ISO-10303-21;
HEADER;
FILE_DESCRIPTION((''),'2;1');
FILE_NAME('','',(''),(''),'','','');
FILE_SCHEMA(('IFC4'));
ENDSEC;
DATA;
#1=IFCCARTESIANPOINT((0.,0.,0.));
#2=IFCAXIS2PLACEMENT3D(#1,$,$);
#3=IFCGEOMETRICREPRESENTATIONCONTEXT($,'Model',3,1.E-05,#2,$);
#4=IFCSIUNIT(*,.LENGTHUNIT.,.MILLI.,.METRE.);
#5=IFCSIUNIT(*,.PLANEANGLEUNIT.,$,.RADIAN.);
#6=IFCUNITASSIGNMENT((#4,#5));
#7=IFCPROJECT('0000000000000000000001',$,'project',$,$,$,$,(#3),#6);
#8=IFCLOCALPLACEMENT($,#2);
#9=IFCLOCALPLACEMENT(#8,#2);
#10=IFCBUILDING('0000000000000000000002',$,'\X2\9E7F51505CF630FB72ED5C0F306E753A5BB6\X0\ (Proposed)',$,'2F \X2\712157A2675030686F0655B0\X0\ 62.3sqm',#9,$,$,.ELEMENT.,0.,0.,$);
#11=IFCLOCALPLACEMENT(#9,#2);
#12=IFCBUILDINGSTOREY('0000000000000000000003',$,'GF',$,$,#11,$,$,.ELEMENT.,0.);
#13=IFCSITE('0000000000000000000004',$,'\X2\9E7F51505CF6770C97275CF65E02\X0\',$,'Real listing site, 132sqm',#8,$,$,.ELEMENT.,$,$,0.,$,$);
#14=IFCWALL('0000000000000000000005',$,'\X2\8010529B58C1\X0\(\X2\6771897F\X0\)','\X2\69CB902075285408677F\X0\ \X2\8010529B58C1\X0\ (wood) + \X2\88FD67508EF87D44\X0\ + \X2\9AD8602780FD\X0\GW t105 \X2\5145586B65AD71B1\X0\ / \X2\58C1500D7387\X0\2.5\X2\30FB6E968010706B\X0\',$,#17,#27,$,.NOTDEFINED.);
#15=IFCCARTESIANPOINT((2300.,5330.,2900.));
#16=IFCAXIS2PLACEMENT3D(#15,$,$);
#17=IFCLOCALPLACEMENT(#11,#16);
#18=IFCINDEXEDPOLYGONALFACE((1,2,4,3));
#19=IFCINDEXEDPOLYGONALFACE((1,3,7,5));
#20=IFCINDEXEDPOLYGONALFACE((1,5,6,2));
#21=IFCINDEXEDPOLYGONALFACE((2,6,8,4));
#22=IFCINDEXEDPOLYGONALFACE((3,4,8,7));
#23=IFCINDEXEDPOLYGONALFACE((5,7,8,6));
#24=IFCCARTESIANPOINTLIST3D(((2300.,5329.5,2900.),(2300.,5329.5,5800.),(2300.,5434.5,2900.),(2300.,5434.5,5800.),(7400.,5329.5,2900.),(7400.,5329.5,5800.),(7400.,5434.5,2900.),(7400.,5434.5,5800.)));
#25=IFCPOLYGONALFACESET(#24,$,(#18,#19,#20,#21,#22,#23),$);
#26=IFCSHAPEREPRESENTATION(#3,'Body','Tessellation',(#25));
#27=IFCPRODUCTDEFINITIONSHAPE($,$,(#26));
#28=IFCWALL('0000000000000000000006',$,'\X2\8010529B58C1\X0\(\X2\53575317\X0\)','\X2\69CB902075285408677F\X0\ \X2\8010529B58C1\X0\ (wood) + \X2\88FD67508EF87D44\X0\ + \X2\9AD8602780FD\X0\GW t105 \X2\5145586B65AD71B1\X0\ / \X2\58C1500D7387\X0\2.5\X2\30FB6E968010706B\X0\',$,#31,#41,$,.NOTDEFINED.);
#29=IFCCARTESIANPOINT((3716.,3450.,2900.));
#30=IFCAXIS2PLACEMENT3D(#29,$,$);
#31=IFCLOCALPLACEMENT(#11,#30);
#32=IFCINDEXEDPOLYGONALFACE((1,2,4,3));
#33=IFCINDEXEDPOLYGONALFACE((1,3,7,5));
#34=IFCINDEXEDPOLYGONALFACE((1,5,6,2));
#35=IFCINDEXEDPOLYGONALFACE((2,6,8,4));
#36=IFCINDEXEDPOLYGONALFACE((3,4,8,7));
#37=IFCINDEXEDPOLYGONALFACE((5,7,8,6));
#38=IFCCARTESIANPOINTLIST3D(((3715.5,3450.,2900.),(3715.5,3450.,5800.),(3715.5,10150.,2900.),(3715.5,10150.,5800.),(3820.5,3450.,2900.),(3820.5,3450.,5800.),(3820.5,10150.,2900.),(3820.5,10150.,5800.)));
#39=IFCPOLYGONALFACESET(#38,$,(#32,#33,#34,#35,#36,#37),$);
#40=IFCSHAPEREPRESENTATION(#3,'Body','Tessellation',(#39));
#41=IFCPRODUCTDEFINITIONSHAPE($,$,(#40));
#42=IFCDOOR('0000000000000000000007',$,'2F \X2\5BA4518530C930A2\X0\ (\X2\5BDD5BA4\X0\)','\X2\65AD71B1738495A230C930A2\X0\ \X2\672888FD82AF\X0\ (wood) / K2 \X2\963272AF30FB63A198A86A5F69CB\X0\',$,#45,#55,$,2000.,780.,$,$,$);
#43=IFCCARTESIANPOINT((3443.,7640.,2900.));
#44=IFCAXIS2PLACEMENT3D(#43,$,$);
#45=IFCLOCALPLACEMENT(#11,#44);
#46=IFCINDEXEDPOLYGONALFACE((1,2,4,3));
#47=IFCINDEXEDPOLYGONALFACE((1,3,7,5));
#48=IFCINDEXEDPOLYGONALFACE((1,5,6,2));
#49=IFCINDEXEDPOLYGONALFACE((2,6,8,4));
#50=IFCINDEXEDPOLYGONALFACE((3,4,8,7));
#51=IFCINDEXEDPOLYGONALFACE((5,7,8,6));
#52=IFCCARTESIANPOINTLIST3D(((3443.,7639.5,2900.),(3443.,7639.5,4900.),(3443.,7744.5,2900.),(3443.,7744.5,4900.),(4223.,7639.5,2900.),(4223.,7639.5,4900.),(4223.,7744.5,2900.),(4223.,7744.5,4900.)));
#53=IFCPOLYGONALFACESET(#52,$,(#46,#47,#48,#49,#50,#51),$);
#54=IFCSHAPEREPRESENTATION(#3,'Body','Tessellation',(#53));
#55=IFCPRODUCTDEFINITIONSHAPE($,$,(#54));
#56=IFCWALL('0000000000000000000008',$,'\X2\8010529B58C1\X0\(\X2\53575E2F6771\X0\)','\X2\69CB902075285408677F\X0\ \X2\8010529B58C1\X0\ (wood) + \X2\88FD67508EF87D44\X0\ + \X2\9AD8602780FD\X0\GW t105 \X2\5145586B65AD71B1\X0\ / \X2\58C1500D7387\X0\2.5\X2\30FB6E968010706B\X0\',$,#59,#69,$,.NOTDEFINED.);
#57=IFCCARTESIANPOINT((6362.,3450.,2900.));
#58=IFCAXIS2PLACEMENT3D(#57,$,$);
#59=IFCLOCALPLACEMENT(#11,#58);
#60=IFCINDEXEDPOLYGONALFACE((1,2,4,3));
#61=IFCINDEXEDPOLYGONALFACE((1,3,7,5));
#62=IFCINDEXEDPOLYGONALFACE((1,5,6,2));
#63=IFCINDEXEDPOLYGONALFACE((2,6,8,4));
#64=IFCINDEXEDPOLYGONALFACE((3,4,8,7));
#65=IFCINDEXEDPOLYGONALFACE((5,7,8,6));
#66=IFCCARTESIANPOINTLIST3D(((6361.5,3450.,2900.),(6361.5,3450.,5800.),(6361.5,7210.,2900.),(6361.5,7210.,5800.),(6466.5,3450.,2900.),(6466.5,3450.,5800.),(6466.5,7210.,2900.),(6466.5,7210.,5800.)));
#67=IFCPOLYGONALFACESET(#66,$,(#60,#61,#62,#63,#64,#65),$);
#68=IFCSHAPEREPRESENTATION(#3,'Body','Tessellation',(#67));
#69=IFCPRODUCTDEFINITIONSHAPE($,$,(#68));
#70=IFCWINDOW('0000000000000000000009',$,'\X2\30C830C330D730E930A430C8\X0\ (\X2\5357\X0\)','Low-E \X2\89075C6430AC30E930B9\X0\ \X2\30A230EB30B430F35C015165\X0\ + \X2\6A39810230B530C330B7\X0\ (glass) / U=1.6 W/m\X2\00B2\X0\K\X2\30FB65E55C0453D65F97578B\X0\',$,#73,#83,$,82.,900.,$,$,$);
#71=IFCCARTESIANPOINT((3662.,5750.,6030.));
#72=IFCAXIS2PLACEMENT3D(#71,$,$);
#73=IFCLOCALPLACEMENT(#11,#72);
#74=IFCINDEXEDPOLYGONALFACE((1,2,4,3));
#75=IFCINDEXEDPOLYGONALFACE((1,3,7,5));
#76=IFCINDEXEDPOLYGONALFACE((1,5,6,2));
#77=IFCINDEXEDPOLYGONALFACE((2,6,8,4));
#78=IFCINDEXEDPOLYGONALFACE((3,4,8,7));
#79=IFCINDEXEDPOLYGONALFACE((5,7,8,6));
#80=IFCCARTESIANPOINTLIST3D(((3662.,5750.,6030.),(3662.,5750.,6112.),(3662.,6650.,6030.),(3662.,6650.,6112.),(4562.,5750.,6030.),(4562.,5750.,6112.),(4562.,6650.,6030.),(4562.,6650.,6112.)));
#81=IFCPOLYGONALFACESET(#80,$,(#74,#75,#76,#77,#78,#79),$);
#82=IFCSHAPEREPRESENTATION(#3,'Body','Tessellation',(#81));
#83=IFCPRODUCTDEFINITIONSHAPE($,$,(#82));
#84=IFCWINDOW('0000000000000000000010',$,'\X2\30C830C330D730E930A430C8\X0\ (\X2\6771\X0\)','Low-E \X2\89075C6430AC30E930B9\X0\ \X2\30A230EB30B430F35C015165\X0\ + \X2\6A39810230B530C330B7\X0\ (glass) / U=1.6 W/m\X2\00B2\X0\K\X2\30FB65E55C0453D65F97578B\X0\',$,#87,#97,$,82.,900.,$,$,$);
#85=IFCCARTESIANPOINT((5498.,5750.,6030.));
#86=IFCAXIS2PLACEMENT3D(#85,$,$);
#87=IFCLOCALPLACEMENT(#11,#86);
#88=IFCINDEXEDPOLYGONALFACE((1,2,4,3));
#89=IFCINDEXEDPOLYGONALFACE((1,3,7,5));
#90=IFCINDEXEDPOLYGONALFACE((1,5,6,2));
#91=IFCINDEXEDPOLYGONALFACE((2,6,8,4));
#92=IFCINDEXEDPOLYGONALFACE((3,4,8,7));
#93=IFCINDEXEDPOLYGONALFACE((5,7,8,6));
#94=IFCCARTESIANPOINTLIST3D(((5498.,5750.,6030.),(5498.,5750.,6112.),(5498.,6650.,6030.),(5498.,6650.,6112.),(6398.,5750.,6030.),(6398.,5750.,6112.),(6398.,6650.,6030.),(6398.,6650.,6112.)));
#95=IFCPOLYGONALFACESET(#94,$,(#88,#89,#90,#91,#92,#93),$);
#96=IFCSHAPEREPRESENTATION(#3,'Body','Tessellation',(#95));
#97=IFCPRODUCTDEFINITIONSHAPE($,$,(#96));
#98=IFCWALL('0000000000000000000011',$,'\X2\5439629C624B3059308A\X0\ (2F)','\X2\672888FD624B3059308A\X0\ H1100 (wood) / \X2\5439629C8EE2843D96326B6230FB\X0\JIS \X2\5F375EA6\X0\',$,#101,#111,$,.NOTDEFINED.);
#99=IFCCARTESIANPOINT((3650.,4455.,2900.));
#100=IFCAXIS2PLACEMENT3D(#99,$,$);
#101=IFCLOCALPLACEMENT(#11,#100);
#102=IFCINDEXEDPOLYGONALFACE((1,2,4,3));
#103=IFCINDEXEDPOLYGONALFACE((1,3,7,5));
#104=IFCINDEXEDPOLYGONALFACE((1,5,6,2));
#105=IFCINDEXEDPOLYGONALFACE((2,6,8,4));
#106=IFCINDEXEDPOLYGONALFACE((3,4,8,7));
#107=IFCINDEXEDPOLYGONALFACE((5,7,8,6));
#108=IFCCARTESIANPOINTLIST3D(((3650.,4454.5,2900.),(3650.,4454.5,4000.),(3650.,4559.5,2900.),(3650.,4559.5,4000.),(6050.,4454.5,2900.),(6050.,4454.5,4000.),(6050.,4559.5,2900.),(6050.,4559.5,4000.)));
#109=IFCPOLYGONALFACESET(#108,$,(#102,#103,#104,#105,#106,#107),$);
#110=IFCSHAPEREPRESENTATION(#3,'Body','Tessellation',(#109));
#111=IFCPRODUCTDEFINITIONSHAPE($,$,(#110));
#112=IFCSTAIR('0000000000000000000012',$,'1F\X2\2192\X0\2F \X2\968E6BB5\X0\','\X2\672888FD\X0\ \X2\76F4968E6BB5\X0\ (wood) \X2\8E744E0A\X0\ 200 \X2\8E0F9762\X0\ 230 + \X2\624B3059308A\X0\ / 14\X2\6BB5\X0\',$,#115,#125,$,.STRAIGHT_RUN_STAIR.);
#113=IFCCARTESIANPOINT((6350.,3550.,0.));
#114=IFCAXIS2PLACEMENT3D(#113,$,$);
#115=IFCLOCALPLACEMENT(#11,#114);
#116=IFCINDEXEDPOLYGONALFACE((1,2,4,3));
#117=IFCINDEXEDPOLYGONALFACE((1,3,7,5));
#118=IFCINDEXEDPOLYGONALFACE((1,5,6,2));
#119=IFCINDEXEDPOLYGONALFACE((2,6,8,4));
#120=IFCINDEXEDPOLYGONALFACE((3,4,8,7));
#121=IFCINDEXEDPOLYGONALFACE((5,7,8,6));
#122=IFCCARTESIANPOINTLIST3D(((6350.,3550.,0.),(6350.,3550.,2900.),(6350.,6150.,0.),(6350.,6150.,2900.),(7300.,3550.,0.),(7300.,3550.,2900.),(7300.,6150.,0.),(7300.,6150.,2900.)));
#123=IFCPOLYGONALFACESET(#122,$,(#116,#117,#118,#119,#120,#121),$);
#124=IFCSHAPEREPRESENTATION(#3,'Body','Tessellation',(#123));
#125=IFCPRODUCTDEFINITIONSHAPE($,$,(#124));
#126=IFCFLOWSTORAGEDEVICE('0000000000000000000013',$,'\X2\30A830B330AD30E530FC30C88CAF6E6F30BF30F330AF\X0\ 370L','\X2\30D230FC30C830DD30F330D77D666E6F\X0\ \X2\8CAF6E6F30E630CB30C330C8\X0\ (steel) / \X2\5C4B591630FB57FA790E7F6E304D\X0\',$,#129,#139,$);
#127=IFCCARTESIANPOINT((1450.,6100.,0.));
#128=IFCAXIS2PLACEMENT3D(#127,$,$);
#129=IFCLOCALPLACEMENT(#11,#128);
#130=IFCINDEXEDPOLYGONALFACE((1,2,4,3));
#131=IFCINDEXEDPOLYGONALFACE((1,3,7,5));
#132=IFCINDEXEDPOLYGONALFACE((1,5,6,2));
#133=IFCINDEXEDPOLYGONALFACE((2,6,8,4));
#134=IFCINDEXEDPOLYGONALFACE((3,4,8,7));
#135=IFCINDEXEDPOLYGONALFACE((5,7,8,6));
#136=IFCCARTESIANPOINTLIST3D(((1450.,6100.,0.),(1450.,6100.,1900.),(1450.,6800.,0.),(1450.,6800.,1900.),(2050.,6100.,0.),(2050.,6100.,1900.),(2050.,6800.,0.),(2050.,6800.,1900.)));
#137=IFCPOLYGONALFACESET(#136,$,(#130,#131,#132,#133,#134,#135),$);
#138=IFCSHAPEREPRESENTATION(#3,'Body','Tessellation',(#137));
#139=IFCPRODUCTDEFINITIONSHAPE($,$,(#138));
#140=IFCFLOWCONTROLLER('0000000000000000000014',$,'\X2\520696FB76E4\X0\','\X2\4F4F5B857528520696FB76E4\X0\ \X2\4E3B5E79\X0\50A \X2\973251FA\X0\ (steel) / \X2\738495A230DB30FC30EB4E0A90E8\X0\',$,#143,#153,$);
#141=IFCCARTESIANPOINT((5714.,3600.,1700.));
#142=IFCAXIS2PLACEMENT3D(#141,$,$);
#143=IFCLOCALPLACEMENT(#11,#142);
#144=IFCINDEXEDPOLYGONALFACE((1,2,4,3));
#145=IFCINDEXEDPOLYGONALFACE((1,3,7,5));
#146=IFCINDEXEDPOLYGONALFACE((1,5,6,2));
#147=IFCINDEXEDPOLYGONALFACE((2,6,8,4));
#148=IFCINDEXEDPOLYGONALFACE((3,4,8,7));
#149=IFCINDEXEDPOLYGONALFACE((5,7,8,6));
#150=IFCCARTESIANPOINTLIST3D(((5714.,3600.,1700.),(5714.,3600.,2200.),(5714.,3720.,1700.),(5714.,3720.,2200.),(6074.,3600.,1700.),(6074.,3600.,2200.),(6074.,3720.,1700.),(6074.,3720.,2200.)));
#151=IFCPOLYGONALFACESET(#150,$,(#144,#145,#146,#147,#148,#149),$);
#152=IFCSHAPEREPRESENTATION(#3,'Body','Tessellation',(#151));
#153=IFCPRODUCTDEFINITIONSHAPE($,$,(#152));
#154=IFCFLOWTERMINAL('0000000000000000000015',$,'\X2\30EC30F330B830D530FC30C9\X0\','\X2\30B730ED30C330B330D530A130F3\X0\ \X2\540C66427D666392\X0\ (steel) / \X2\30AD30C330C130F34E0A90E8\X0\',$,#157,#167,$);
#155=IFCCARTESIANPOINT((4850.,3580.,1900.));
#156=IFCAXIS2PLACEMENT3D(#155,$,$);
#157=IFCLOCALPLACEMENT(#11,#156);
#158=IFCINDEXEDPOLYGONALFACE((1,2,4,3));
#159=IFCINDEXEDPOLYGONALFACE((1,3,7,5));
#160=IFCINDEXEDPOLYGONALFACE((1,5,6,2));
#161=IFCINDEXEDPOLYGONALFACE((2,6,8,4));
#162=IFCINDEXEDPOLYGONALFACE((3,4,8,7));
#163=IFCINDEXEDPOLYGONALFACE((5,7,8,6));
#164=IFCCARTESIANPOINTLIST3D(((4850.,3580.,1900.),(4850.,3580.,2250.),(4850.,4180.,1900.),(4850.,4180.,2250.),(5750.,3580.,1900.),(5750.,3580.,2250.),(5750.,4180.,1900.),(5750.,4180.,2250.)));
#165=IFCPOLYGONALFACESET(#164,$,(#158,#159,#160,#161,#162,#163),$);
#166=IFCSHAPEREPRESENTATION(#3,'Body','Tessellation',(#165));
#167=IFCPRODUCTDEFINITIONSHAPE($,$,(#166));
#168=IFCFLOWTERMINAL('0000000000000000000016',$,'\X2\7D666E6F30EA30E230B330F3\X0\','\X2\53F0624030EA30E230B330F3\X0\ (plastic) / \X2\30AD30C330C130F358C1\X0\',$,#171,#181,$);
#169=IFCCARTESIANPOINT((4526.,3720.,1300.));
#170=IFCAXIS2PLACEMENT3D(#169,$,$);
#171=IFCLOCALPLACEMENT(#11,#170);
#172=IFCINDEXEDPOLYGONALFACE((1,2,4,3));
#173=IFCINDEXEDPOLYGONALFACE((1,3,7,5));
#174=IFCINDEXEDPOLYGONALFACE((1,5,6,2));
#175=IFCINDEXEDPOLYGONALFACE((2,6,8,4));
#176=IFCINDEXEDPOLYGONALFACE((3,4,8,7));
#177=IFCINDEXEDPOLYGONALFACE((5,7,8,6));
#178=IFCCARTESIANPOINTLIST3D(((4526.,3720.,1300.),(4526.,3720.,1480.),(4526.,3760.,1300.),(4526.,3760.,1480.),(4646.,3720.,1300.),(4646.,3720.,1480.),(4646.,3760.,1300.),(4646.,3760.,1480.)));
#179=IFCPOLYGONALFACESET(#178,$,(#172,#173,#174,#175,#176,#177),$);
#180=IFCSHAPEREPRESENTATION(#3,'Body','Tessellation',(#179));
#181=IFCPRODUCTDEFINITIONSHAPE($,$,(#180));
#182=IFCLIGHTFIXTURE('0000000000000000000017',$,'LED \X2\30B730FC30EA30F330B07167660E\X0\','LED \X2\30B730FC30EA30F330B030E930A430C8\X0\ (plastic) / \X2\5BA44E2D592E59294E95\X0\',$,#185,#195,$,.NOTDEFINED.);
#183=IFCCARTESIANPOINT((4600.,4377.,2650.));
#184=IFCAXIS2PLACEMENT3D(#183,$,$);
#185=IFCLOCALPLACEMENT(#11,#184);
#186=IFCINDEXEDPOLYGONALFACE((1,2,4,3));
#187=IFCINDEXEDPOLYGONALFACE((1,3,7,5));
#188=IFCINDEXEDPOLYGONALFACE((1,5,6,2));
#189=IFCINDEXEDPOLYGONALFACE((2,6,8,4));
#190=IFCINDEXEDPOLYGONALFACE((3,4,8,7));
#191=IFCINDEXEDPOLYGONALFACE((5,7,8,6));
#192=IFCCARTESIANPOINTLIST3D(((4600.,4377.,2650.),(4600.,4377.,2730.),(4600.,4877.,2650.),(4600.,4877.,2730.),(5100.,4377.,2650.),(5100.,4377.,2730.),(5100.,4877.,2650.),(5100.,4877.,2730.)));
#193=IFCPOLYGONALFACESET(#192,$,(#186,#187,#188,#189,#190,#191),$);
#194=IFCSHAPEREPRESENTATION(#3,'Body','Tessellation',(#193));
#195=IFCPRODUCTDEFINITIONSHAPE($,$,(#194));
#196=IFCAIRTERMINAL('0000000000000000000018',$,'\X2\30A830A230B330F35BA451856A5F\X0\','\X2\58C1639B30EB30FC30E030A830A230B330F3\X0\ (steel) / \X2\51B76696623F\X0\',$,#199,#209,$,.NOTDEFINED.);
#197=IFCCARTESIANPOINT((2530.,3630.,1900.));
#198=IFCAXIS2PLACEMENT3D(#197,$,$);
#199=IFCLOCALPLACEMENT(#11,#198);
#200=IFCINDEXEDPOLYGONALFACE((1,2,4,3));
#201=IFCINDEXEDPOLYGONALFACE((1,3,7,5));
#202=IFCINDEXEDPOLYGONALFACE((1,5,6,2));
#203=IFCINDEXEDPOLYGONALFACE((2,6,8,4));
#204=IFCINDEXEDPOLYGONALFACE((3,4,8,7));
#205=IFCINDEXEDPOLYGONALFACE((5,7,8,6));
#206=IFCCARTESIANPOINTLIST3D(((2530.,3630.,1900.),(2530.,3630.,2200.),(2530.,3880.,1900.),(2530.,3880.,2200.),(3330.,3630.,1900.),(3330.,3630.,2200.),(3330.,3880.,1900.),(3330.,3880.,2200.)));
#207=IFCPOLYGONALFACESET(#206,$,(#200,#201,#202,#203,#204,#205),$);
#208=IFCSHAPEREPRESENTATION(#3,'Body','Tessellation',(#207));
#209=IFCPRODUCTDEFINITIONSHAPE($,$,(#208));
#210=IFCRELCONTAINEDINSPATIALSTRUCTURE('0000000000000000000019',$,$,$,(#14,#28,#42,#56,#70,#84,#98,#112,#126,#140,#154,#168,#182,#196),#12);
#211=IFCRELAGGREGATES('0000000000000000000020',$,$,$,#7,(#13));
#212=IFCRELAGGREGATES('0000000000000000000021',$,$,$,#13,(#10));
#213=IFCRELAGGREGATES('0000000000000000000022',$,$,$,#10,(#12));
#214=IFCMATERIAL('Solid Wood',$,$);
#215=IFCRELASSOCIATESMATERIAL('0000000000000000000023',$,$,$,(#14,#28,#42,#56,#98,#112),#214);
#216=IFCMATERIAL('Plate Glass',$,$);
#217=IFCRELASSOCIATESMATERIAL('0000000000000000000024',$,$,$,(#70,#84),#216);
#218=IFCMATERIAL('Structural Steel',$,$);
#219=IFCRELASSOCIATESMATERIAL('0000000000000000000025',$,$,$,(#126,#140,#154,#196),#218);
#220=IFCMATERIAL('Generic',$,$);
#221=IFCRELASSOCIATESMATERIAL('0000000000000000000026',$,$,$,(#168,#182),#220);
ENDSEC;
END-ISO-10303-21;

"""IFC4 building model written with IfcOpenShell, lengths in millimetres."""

from ifc_helpers import new_model, si_unit, frame, frame_2d, origin, place, context, project, spatial, rectangle, extrude, material, element, fill, save


model = new_model("IFC4")

# Units and contexts
model_context = context("Model", 3, precision=1e-05, world=origin())
ifc_project = project(units=[si_unit("LENGTHUNIT", "METRE", prefix="MILLI"), si_unit("PLANEANGLEUNIT", "RADIAN")], contexts=[model_context])

# Site, building, storey
site_placement = place(None, origin())
site = spatial("IfcSite", under=ifc_project, at=site_placement, Name="鹿児島県霧島市", ObjectType="Real listing site, 132sqm", CompositionType="ELEMENT", RefElevation=0.0)
building_placement = place(site_placement, origin())
building = spatial("IfcBuilding", under=site, at=building_placement, Name="鹿児島・狭小の町家 (Proposed)", ObjectType="2F 無垢材と漆喰 62.3sqm", CompositionType="ELEMENT", ElevationOfRefHeight=0.0, ElevationOfTerrain=0.0)
storey_placement = place(building_placement, origin())
storey = spatial("IfcBuildingStorey", under=building, at=storey_placement, Name="GF", CompositionType="ELEMENT", Elevation=0.0)

# Shared definitions
ifc_material_1 = material(Name="Solid Wood")

# Wall
wall_1_placement = place(storey_placement, frame((2300.0, 5330.0, 2900.0)))
element("IfcWall", 1, at=wall_1_placement, inside=storey, material=ifc_material_1, Name="耐力壁(東西)", Description="構造用合板 耐力壁 (wood) + 製材軸組 + 高性能GW t105 充填断熱 / 壁倍率2.5・準耐火", PredefinedType="NOTDEFINED", context=model_context, shape_type="SweptSolid", body=[
    extrude(rectangle(XDim=5100.0, YDim=105.0, at=frame_2d((2550.0, 52.0))), frame((2300.0, 5330.0, 2900.0)), (0.0, 0.0, 1.0), 2900.0),
])

# Wall, opening, door
wall_2_placement = place(storey_placement, frame((3716.0, 3450.0, 2900.0)))
wall_2 = element("IfcWall", 2, at=wall_2_placement, inside=storey, material=ifc_material_1, Name="耐力壁(南北)", Description="構造用合板 耐力壁 (wood) + 製材軸組 + 高性能GW t105 充填断熱 / 壁倍率2.5・準耐火", PredefinedType="NOTDEFINED", context=model_context, shape_type="SweptSolid", body=[
    extrude(rectangle(XDim=105.0, YDim=6700.0, at=frame_2d((52.0, 3350.0))), frame((3716.0, 3450.0, 2900.0)), (0.0, 0.0, 1.0), 2900.0),
])
opening_placement = place(storey_placement, frame((3443.0, 7640.0, 2900.0)))
opening = element("IfcOpeningElement", 3, at=opening_placement, cuts=wall_2, PredefinedType="NOTDEFINED", context=model_context, shape_type="SweptSolid", body=[
    extrude(rectangle(XDim=780.0, YDim=105.0, at=frame_2d((390.0, 52.0))), frame((3443.0, 7640.0, 2900.0)), (0.0, 0.0, 1.0), 2000.0),
])
door_placement = place(storey_placement, frame((3443.0, 7640.0, 2900.0)))
door = element("IfcDoor", 4, at=door_placement, inside=storey, material=ifc_material_1, Name="2F 室内ドア (寝室)", Description="断熱玄関ドア 木製芯 (wood) / K2 防犯・採風機構", OverallHeight=2000.0, OverallWidth=780.0, context=model_context, shape_type="SweptSolid", body=[
    extrude(rectangle(XDim=780.0, YDim=105.0, at=frame_2d((390.0, 52.0))), frame((3443.0, 7640.0, 2900.0)), (0.0, 0.0, 1.0), 2000.0),
])
fill(opening, door)

# Wall
wall_3_placement = place(storey_placement, frame((6362.0, 3450.0, 2900.0)))
element("IfcWall", 5, at=wall_3_placement, inside=storey, material=ifc_material_1, Name="耐力壁(南帯東)", Description="構造用合板 耐力壁 (wood) + 製材軸組 + 高性能GW t105 充填断熱 / 壁倍率2.5・準耐火", PredefinedType="NOTDEFINED", context=model_context, shape_type="SweptSolid", body=[
    extrude(rectangle(XDim=105.0, YDim=3760.0, at=frame_2d((52.0, 1880.0))), frame((6362.0, 3450.0, 2900.0)), (0.0, 0.0, 1.0), 2900.0),
])

# Windows
ifc_material_2 = material(Name="Plate Glass")
window_1_placement = place(storey_placement, frame((3662.0, 5750.0, 6030.0)))
element("IfcWindow", 6, at=window_1_placement, inside=storey, material=ifc_material_2, Name="トップライト (南)", Description="Low-E 複層ガラス アルゴン封入 + 樹脂サッシ (glass) / U=1.6 W/m²K・日射取得型", OverallHeight=82.0, OverallWidth=900.0, context=model_context, shape_type="SweptSolid", body=[
    extrude(rectangle(XDim=900.0, YDim=900.0, at=frame_2d((450.0, 450.0))), frame((3662.0, 5750.0, 6030.0)), (0.0, 0.0, 1.0), 82.0),
])
window_2_placement = place(storey_placement, frame((5498.0, 5750.0, 6030.0)))
element("IfcWindow", 7, at=window_2_placement, inside=storey, material=ifc_material_2, Name="トップライト (東)", Description="Low-E 複層ガラス アルゴン封入 + 樹脂サッシ (glass) / U=1.6 W/m²K・日射取得型", OverallHeight=82.0, OverallWidth=900.0, context=model_context, shape_type="SweptSolid", body=[
    extrude(rectangle(XDim=900.0, YDim=900.0, at=frame_2d((450.0, 450.0))), frame((5498.0, 5750.0, 6030.0)), (0.0, 0.0, 1.0), 82.0),
])

# Wall
wall_4_placement = place(storey_placement, frame((3650.0, 4455.0, 2900.0)))
element("IfcWall", 8, at=wall_4_placement, inside=storey, material=ifc_material_1, Name="吹抜手すり (2F)", Description="木製手すり H1100 (wood) / 吹抜転落防止・JIS 強度", PredefinedType="NOTDEFINED", context=model_context, shape_type="SweptSolid", body=[
    extrude(rectangle(XDim=2400.0, YDim=105.0, at=frame_2d((1200.0, 52.0))), frame((3650.0, 4455.0, 2900.0)), (0.0, 0.0, 1.0), 1100.0),
])

# Stair
stair_placement = place(storey_placement, frame((6350.0, 3550.0, 0.0)))
element("IfcStair", 9, at=stair_placement, inside=storey, material=ifc_material_1, Name="1F→2F 階段", Description="木製 直階段 (wood) 蹴上 200 踏面 230 + 手すり / 14段", PredefinedType="STRAIGHT_RUN_STAIR", context=model_context, shape_type="SweptSolid", body=[
    extrude(rectangle(XDim=950.0, YDim=2600.0, at=frame_2d((475.0, 1300.0))), frame((6350.0, 3550.0, 0.0)), (0.0, 0.0, 1.0), 2900.0),
])

# Flow storage device
ifc_material_3 = material(Name="Structural Steel")
flow_storage_device_placement = place(storey_placement, frame((1450.0, 6100.0, 0.0)))
element("IfcFlowStorageDevice", 10, at=flow_storage_device_placement, inside=storey, material=ifc_material_3, Name="エコキュート貯湯タンク 370L", Description="ヒートポンプ給湯 貯湯ユニット (steel) / 屋外・基礎置き", context=model_context, shape_type="SweptSolid", body=[
    extrude(rectangle(XDim=600.0, YDim=700.0, at=frame_2d((300.0, 350.0))), frame((1450.0, 6100.0, 0.0)), (0.0, 0.0, 1.0), 1900.0),
])

# Flow controller
flow_controller_placement = place(storey_placement, frame((5714.0, 3600.0, 1700.0)))
element("IfcFlowController", 11, at=flow_controller_placement, inside=storey, material=ifc_material_3, Name="分電盤", Description="住宅用分電盤 主幹50A 露出 (steel) / 玄関ホール上部", context=model_context, shape_type="SweptSolid", body=[
    extrude(rectangle(XDim=360.0, YDim=120.0, at=frame_2d((180.0, 60.0))), frame((5714.0, 3600.0, 1700.0)), (0.0, 0.0, 1.0), 500.0),
])

# Flow terminals
flow_terminal_1_placement = place(storey_placement, frame((4850.0, 3580.0, 1900.0)))
element("IfcFlowTerminal", 12, at=flow_terminal_1_placement, inside=storey, material=ifc_material_3, Name="レンジフード", Description="シロッコファン 同時給排 (steel) / キッチン上部", context=model_context, shape_type="SweptSolid", body=[
    extrude(rectangle(XDim=900.0, YDim=600.0, at=frame_2d((450.0, 300.0))), frame((4850.0, 3580.0, 1900.0)), (0.0, 0.0, 1.0), 350.0),
])
ifc_material_4 = material(Name="Generic")
flow_terminal_2_placement = place(storey_placement, frame((4526.0, 3720.0, 1300.0)))
element("IfcFlowTerminal", 13, at=flow_terminal_2_placement, inside=storey, material=ifc_material_4, Name="給湯リモコン", Description="台所リモコン (plastic) / キッチン壁", context=model_context, shape_type="SweptSolid", body=[
    extrude(rectangle(XDim=120.0, YDim=40.0, at=frame_2d((60.0, 20.0))), frame((4526.0, 3720.0, 1300.0)), (0.0, 0.0, 1.0), 180.0),
])

# Light fixture
light_fixture_1_placement = place(storey_placement, frame((4600.0, 4377.0, 2650.0)))
element("IfcLightFixture", 14, at=light_fixture_1_placement, inside=storey, material=ifc_material_4, Name="LED シーリング照明", Description="LED シーリングライト (plastic) / 室中央天井", PredefinedType="NOTDEFINED", context=model_context, shape_type="SweptSolid", body=[
    extrude(rectangle(XDim=500.0, YDim=500.0, at=frame_2d((250.0, 250.0))), frame((4600.0, 4377.0, 2650.0)), (0.0, 0.0, 1.0), 80.0),
])

# Air terminal
air_terminal_1_placement = place(storey_placement, frame((2530.0, 3630.0, 1900.0)))
element("IfcAirTerminal", 15, at=air_terminal_1_placement, inside=storey, material=ifc_material_3, Name="エアコン室内機", Description="壁掛ルームエアコン (steel) / 冷暖房", PredefinedType="NOTDEFINED", context=model_context, shape_type="SweptSolid", body=[
    extrude(rectangle(XDim=800.0, YDim=250.0, at=frame_2d((400.0, 125.0))), frame((2530.0, 3630.0, 1900.0)), (0.0, 0.0, 1.0), 300.0),
])

save(model, "model.ifc")
